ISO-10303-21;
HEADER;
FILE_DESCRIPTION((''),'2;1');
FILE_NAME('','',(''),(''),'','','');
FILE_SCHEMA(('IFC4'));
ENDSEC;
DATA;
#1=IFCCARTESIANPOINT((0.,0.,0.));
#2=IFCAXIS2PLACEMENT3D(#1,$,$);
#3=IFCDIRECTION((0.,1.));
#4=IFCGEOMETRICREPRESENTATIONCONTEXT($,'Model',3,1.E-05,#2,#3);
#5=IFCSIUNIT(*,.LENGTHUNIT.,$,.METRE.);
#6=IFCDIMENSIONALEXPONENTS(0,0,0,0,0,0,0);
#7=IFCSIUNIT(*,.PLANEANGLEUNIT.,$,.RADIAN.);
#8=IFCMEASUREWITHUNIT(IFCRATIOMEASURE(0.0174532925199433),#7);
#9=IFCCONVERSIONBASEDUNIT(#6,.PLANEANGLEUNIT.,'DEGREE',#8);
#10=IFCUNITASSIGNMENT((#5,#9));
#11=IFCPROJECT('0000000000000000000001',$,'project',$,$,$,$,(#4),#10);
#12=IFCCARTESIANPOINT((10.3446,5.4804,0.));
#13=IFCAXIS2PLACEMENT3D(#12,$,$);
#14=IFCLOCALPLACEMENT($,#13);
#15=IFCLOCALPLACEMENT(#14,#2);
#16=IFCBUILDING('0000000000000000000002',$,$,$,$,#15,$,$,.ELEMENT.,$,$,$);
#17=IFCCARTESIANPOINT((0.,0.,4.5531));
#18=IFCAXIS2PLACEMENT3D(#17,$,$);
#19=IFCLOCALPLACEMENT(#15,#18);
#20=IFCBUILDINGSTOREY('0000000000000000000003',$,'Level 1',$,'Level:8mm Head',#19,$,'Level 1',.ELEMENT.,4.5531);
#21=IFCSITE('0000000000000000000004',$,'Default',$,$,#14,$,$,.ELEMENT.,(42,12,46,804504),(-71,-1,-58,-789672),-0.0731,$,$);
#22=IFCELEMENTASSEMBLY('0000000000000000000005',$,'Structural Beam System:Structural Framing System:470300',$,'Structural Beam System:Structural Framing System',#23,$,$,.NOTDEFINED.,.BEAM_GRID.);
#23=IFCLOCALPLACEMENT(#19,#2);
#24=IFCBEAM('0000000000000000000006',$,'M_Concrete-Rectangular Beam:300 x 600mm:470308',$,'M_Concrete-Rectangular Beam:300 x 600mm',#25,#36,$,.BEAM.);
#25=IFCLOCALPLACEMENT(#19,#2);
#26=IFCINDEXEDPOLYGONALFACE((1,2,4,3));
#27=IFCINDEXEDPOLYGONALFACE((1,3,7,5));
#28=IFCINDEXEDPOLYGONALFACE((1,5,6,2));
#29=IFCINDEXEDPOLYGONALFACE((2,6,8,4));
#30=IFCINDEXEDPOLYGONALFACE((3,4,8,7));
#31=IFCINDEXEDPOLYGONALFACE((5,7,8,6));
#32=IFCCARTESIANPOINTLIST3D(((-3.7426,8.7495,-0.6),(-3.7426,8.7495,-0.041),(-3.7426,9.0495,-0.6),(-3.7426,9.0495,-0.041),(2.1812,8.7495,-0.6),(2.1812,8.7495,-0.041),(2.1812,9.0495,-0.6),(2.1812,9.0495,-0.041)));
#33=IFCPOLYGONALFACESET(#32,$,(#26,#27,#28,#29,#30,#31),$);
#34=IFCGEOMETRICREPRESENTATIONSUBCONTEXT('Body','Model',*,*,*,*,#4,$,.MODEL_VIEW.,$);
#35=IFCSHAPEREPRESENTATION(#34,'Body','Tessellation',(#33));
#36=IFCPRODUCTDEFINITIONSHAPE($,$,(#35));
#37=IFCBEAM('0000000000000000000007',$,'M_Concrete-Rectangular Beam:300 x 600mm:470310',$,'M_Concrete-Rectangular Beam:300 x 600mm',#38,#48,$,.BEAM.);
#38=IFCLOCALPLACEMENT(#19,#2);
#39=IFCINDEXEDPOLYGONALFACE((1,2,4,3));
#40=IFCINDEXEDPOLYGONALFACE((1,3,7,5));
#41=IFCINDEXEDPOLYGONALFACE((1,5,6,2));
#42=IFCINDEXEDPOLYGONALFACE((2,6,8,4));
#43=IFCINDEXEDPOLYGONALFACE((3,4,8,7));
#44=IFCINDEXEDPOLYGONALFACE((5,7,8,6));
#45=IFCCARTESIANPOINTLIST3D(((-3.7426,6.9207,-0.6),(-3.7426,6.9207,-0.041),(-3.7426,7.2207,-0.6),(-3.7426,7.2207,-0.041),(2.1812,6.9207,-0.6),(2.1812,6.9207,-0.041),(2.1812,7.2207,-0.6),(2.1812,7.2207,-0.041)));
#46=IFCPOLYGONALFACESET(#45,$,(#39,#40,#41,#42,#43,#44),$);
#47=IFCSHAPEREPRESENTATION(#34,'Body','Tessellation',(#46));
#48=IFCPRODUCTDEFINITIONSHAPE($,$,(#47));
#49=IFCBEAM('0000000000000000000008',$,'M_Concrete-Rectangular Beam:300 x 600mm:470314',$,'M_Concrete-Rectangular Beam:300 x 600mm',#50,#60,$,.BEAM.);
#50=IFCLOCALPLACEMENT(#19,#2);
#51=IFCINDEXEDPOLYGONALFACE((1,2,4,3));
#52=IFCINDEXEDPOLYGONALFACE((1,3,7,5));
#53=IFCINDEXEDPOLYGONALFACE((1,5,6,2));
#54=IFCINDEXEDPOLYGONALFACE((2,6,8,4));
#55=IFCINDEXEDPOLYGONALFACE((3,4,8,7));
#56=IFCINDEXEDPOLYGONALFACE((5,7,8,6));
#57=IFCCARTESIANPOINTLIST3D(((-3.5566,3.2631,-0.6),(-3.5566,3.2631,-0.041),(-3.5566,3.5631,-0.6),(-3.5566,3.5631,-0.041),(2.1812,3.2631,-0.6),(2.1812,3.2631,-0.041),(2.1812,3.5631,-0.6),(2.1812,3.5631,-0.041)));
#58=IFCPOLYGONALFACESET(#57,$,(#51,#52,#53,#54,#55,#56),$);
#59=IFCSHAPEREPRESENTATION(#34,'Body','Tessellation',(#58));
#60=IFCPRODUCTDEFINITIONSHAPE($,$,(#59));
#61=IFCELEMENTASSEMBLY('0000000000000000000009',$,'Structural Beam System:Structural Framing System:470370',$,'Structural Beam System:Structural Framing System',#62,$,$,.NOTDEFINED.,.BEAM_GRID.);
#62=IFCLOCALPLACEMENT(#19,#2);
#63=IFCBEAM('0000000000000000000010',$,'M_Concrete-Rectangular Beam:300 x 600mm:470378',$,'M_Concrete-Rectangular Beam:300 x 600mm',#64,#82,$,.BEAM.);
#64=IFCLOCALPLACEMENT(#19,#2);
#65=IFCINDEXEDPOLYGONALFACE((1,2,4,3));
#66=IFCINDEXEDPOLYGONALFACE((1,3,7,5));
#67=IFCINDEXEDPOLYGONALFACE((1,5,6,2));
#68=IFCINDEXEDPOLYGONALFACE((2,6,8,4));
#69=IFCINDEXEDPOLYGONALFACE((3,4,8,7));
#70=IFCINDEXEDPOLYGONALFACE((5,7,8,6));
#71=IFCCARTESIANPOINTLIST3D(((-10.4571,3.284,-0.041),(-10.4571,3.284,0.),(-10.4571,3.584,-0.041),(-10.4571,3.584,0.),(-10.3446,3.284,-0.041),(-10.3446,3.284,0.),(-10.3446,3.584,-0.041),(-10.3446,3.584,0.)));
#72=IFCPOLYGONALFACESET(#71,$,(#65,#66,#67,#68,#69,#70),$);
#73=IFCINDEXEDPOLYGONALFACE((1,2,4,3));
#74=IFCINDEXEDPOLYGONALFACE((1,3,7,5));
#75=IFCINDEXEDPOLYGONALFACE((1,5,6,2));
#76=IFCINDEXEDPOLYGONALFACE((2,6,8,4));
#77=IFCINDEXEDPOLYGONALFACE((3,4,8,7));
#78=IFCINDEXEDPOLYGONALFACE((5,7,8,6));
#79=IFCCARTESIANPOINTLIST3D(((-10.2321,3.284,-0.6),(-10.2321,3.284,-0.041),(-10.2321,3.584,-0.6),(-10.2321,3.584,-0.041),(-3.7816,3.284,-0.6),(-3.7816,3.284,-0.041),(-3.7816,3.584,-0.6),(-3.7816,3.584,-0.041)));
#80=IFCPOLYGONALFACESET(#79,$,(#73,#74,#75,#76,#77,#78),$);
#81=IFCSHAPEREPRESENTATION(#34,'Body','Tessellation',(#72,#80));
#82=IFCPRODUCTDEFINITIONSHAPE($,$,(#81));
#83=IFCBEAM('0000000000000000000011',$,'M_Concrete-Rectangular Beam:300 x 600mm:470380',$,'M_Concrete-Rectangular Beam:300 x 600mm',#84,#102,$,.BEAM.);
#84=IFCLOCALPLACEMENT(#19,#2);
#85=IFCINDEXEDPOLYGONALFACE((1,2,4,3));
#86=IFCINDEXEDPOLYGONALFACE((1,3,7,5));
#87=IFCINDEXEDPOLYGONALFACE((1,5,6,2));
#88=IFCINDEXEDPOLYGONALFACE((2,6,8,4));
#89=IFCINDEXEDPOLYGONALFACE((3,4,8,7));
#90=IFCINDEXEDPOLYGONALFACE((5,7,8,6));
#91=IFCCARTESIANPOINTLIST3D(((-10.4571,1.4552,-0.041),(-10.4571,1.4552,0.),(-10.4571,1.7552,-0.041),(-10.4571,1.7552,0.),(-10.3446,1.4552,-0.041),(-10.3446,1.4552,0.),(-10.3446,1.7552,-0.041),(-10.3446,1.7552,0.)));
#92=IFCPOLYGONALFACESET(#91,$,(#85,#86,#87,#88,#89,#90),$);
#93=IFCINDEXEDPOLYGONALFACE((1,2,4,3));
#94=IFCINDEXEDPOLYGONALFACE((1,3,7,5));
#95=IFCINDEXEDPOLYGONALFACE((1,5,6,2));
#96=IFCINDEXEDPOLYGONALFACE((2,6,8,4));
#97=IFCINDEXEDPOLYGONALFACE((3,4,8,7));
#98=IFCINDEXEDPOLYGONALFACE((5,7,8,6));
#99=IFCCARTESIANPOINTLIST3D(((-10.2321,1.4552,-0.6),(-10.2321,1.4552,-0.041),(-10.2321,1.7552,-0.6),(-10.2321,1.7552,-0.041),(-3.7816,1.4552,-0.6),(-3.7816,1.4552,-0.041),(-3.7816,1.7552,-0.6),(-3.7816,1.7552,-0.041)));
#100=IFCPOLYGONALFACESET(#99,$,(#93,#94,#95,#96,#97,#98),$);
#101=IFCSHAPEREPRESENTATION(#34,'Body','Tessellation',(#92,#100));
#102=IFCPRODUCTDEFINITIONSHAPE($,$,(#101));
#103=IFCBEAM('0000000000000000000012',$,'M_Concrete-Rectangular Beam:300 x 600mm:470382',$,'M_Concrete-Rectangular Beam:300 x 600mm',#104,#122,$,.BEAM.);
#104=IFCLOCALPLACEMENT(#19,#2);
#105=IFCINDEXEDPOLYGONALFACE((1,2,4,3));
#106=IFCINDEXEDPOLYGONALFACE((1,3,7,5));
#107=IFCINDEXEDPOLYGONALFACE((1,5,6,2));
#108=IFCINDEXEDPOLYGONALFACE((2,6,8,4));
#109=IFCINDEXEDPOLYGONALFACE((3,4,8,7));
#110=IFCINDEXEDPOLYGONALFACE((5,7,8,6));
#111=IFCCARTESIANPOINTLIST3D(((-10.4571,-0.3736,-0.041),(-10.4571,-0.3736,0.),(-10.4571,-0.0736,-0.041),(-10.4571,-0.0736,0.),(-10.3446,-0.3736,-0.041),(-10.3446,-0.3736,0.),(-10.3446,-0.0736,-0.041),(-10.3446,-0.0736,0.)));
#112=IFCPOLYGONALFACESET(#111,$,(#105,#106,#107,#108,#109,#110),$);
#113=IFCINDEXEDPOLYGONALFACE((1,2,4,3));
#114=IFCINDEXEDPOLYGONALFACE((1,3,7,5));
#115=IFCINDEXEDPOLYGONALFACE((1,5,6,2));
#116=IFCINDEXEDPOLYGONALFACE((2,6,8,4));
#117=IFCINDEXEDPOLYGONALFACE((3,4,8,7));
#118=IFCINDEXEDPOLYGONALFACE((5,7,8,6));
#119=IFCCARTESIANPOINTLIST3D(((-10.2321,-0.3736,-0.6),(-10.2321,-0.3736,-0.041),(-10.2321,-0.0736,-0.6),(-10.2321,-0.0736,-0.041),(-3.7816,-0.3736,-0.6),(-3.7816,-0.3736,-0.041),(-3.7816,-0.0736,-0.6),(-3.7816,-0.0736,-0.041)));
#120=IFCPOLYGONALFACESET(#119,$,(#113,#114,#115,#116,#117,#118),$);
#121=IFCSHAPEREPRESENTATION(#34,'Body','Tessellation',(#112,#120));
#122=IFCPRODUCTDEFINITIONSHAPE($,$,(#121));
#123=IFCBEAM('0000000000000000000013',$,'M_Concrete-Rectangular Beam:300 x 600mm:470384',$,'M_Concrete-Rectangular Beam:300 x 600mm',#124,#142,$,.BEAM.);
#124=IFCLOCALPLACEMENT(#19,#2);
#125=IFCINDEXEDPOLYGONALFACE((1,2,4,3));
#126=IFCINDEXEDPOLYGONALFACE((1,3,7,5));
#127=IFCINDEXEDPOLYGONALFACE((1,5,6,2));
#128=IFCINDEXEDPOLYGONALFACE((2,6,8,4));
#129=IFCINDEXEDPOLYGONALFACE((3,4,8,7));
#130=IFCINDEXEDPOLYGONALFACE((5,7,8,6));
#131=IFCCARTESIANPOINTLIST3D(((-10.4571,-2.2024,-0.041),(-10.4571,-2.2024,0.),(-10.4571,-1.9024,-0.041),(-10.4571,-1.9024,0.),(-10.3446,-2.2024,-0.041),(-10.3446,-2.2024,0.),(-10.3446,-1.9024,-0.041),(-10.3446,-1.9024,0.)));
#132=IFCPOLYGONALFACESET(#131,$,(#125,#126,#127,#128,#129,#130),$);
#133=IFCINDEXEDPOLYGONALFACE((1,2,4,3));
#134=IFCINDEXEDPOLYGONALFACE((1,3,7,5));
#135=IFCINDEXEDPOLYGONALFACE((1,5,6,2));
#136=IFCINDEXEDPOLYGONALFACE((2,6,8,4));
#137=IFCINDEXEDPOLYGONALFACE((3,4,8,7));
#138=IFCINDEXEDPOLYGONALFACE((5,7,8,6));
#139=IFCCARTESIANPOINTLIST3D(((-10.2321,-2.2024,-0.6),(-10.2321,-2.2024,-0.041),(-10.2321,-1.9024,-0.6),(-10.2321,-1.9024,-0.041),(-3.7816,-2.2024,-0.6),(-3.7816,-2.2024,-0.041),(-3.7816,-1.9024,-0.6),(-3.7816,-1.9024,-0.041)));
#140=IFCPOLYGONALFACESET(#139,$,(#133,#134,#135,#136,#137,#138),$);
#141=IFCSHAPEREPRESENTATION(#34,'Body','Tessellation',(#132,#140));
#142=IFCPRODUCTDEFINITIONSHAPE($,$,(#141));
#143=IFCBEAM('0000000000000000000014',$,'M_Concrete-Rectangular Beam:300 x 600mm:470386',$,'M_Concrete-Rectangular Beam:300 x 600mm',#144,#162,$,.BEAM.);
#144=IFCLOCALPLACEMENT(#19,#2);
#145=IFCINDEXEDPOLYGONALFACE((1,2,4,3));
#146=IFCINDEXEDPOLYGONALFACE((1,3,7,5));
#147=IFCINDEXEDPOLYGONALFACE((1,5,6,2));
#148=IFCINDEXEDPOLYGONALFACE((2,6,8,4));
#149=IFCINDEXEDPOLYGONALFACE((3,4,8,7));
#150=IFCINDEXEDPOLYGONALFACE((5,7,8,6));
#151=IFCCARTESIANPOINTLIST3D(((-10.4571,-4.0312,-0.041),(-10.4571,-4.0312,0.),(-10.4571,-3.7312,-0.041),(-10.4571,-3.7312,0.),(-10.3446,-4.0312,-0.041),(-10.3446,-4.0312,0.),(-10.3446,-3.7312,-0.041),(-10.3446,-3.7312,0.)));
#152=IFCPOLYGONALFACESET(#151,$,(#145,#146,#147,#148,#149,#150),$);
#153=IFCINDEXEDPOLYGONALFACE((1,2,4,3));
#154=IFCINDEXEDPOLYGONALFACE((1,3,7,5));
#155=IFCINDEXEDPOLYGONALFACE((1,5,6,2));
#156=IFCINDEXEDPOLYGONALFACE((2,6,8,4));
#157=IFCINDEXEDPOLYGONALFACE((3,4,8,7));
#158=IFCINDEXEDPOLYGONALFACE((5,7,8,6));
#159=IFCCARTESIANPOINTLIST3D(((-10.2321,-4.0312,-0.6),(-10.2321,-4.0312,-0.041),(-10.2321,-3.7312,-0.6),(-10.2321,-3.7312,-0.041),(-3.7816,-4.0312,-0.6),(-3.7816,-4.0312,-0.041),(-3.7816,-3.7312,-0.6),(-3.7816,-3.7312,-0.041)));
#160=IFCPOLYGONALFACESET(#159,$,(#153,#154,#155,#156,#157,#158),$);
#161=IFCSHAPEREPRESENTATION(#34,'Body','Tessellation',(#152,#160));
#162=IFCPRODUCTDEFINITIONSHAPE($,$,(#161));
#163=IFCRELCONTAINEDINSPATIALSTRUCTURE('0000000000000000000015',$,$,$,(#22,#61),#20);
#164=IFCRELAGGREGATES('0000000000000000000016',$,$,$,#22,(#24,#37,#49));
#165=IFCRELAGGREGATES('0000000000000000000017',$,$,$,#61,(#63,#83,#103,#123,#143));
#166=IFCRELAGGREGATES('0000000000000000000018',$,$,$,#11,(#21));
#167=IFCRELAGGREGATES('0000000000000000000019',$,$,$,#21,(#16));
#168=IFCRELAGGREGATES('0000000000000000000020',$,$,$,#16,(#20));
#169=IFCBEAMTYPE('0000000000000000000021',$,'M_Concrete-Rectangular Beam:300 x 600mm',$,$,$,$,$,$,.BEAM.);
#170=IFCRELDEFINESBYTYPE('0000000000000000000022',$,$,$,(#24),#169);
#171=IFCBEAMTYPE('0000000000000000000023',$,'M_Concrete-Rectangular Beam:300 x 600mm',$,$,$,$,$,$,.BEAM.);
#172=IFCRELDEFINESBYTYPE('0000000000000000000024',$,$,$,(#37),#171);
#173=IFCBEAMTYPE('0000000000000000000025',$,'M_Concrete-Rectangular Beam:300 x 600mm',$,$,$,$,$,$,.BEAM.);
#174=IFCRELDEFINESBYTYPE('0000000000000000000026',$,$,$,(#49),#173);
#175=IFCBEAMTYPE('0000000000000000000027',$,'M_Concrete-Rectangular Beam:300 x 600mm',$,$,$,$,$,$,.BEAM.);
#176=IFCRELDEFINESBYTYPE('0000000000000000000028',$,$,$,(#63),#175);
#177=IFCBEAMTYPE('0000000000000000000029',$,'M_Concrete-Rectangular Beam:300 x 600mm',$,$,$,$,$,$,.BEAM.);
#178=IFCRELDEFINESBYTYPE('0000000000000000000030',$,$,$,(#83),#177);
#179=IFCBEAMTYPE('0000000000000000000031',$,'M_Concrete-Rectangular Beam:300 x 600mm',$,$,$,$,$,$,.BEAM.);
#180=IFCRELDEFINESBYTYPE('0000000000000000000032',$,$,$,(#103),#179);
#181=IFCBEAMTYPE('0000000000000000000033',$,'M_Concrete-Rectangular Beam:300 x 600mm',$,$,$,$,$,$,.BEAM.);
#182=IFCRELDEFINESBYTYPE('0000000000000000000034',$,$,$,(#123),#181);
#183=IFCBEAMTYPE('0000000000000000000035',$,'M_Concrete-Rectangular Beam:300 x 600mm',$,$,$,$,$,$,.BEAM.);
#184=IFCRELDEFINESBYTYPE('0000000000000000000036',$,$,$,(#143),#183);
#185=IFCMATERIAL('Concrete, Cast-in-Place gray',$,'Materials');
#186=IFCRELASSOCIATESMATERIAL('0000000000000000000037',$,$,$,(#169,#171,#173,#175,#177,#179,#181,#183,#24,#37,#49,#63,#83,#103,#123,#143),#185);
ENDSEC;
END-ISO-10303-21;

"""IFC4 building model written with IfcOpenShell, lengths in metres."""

from ifc_helpers import new_model, entity, si_unit, converted_unit, direction, frame, frame_2d, origin, place, context, subcontext, project, spatial, rectangle, extrude, source, transform, mapped, material, material_profile, profile_set, profile_usage, type_object, type_shapes, element, aggregate, save


model = new_model("IFC4")

# Units and contexts
model_context = context("Model", 3, precision=1e-05, world=origin(), true_north=direction((0.0, 1.0)))
body_context = subcontext(model_context, "Body", "Model", "MODEL_VIEW")
ifc_project = project(units=[si_unit("LENGTHUNIT", "METRE"), converted_unit("PLANEANGLEUNIT", "DEGREE", entity("IfcRatioMeasure", 0.0174532925199433), si_unit("PLANEANGLEUNIT", "RADIAN"), dimensions=[0, 0, 0, 0, 0, 0, 0])], contexts=[model_context])

# Site, building, storey
site_placement = place(None, frame((10.3446, 5.4804, 0.0)))
site = spatial("IfcSite", under=ifc_project, at=site_placement, Name="Default", CompositionType="ELEMENT", RefLatitude=(42, 12, 46, 804504), RefLongitude=(-71, -1, -58, -789672), RefElevation=-0.0731)
building_placement = place(site_placement, origin())
building = spatial("IfcBuilding", under=site, at=building_placement, CompositionType="ELEMENT")
storey_placement = place(building_placement, frame((0.0, 0.0, 4.5531)))
storey = spatial("IfcBuildingStorey", under=building, at=storey_placement, Name="Level 1", ObjectType="Level:8mm Head", LongName="Level 1", CompositionType="ELEMENT", Elevation=4.5531)

# Element assemblies, beams
assembly_1_placement = place(storey_placement, origin())
assembly_1 = element("IfcElementAssembly", 1, at=assembly_1_placement, inside=storey, Name="Structural Beam System:Structural Framing System:470300", ObjectType="Structural Beam System:Structural Framing System", AssemblyPlace="NOTDEFINED", PredefinedType="BEAM_GRID")
ifc_material_1 = material(Name="Concrete, Cast-in-Place gray", Category="Materials")
ifc_material_profile = material_profile(ifc_material_1, rectangle(XDim=0.559, YDim=0.3, at=frame_2d((0.0, 0.0), x_axis=(1.0, 0.0))), Name="300 x 600mm")
ifc_profile_set = profile_set([ifc_material_profile], Name="300 x 600mm")
ifc_profile_usage_1 = profile_usage(ifc_profile_set, cardinal=8)
beam_type_1 = type_object("IfcBeamType", Name="M_Concrete-Rectangular Beam:300 x 600mm", PredefinedType="BEAM", material=ifc_profile_set)
shared_shape_1 = source(origin(), body_context, "Body", "SweptSolid", [
    extrude(rectangle(XDim=0.559, YDim=0.3, at=frame_2d((0.0, 0.0), x_axis=(1.0, 0.0))), frame((-3.7426, 8.8995, 4.2326), z_axis=(1.0, 0.0, 0.0), x_axis=(0.0, 0.0, -1.0)), (0.0, 0.0, 1.0), 5.9238),
])
type_shapes(beam_type_1, [shared_shape_1])
beam_1_placement = place(assembly_1_placement, frame((0.0, 0.0, -4.5531)))
beam_1 = element("IfcBeam", 2, at=beam_1_placement, type_object=beam_type_1, material=ifc_profile_usage_1, Name="M_Concrete-Rectangular Beam:300 x 600mm:470308", ObjectType="M_Concrete-Rectangular Beam:300 x 600mm", PredefinedType="BEAM", context=body_context, shape_type="MappedRepresentation", body=[
    mapped(shared_shape_1, transform((0.0, 0.0, 0.0), scale=1.0)),
])
ifc_profile_usage_2 = profile_usage(ifc_profile_set, cardinal=8)
beam_type_2 = type_object("IfcBeamType", Name="M_Concrete-Rectangular Beam:300 x 600mm", PredefinedType="BEAM", material=ifc_profile_set)
shared_shape_2 = source(origin(), body_context, "Body", "SweptSolid", [
    extrude(rectangle(XDim=0.559, YDim=0.3, at=frame_2d((0.0, 0.0), x_axis=(1.0, 0.0))), frame((-3.7426, 7.0707, 4.2326), z_axis=(1.0, 0.0, 0.0), x_axis=(0.0, 0.0, -1.0)), (0.0, 0.0, 1.0), 5.9238),
])
type_shapes(beam_type_2, [shared_shape_2])
beam_2_placement = place(assembly_1_placement, frame((0.0, 0.0, -4.5531)))
beam_2 = element("IfcBeam", 3, at=beam_2_placement, type_object=beam_type_2, material=ifc_profile_usage_2, Name="M_Concrete-Rectangular Beam:300 x 600mm:470310", ObjectType="M_Concrete-Rectangular Beam:300 x 600mm", PredefinedType="BEAM", context=body_context, shape_type="MappedRepresentation", body=[
    mapped(shared_shape_2, transform((0.0, 0.0, 0.0), scale=1.0)),
])
ifc_profile_usage_3 = profile_usage(ifc_profile_set, cardinal=8)
beam_type_3 = type_object("IfcBeamType", Name="M_Concrete-Rectangular Beam:300 x 600mm", PredefinedType="BEAM", material=ifc_profile_set)
shared_shape_3 = source(origin(), body_context, "Body", "SweptSolid", [
    extrude(rectangle(XDim=0.559, YDim=0.3, at=frame_2d((0.0, 0.0), x_axis=(1.0, 0.0))), frame((-3.5566, 3.4131, 4.2326), z_axis=(1.0, 0.0, 0.0), x_axis=(0.0, 0.0, -1.0)), (0.0, 0.0, 1.0), 5.7377),
])
type_shapes(beam_type_3, [shared_shape_3])
beam_3_placement = place(assembly_1_placement, frame((0.0, 0.0, -4.5531)))
beam_3 = element("IfcBeam", 4, at=beam_3_placement, type_object=beam_type_3, material=ifc_profile_usage_3, Name="M_Concrete-Rectangular Beam:300 x 600mm:470314", ObjectType="M_Concrete-Rectangular Beam:300 x 600mm", PredefinedType="BEAM", context=body_context, shape_type="MappedRepresentation", body=[
    mapped(shared_shape_3, transform((0.0, 0.0, 0.0), scale=1.0)),
])
aggregate(assembly_1, [beam_1, beam_2, beam_3])
assembly_2_placement = place(storey_placement, origin())
assembly_2 = element("IfcElementAssembly", 5, at=assembly_2_placement, inside=storey, Name="Structural Beam System:Structural Framing System:470370", ObjectType="Structural Beam System:Structural Framing System", AssemblyPlace="NOTDEFINED", PredefinedType="BEAM_GRID")
ifc_profile_usage_4 = profile_usage(ifc_profile_set, cardinal=8)
beam_type_4 = type_object("IfcBeamType", Name="M_Concrete-Rectangular Beam:300 x 600mm", PredefinedType="BEAM", material=ifc_profile_set)
shared_shape_4 = source(origin(), body_context, "Body", "SweptSolid", [
    extrude(rectangle(XDim=0.041, YDim=0.3, at=frame_2d((0.0, 0.0), x_axis=(1.0, 0.0))), frame((-10.4571, 3.434, 4.5326), z_axis=(1.0, 0.0, 0.0), x_axis=(0.0, 0.0, -1.0)), (0.0, 0.0, 1.0), 0.1125),
    extrude(rectangle(XDim=0.559, YDim=0.3, at=frame_2d((0.0, 0.0), x_axis=(1.0, 0.0))), frame((-10.2321, 3.434, 4.2326), z_axis=(1.0, 0.0, 0.0), x_axis=(0.0, 0.0, -1.0)), (0.0, 0.0, 1.0), 6.4506),
])
type_shapes(beam_type_4, [shared_shape_4])
beam_4_placement = place(assembly_2_placement, frame((0.0, 0.0, -4.5531)))
beam_4 = element("IfcBeam", 6, at=beam_4_placement, type_object=beam_type_4, material=ifc_profile_usage_4, Name="M_Concrete-Rectangular Beam:300 x 600mm:470378", ObjectType="M_Concrete-Rectangular Beam:300 x 600mm", PredefinedType="BEAM", context=body_context, shape_type="MappedRepresentation", body=[
    mapped(shared_shape_4, transform((0.0, 0.0, 0.0), scale=1.0)),
])
ifc_profile_usage_5 = profile_usage(ifc_profile_set, cardinal=8)
beam_type_5 = type_object("IfcBeamType", Name="M_Concrete-Rectangular Beam:300 x 600mm", PredefinedType="BEAM", material=ifc_profile_set)
shared_shape_5 = source(origin(), body_context, "Body", "SweptSolid", [
    extrude(rectangle(XDim=0.041, YDim=0.3, at=frame_2d((0.0, 0.0), x_axis=(1.0, 0.0))), frame((-10.4571, 1.6052, 4.5326), z_axis=(1.0, 0.0, 0.0), x_axis=(0.0, 0.0, -1.0)), (0.0, 0.0, 1.0), 0.1125),
    extrude(rectangle(XDim=0.559, YDim=0.3, at=frame_2d((0.0, 0.0), x_axis=(1.0, 0.0))), frame((-10.2321, 1.6052, 4.2326), z_axis=(1.0, 0.0, 0.0), x_axis=(0.0, 0.0, -1.0)), (0.0, 0.0, 1.0), 6.4506),
])
type_shapes(beam_type_5, [shared_shape_5])
beam_5_placement = place(assembly_2_placement, frame((0.0, 0.0, -4.5531)))
beam_5 = element("IfcBeam", 7, at=beam_5_placement, type_object=beam_type_5, material=ifc_profile_usage_5, Name="M_Concrete-Rectangular Beam:300 x 600mm:470380", ObjectType="M_Concrete-Rectangular Beam:300 x 600mm", PredefinedType="BEAM", context=body_context, shape_type="MappedRepresentation", body=[
    mapped(shared_shape_5, transform((0.0, 0.0, 0.0), scale=1.0)),
])
ifc_profile_usage_6 = profile_usage(ifc_profile_set, cardinal=8)
beam_type_6 = type_object("IfcBeamType", Name="M_Concrete-Rectangular Beam:300 x 600mm", PredefinedType="BEAM", material=ifc_profile_set)
shared_shape_6 = source(origin(), body_context, "Body", "SweptSolid", [
    extrude(rectangle(XDim=0.041, YDim=0.3, at=frame_2d((0.0, 0.0), x_axis=(1.0, 0.0))), frame((-10.4571, -0.2236, 4.5326), z_axis=(1.0, 0.0, 0.0), x_axis=(0.0, 0.0, -1.0)), (0.0, 0.0, 1.0), 0.1125),
    extrude(rectangle(XDim=0.559, YDim=0.3, at=frame_2d((0.0, 0.0), x_axis=(1.0, 0.0))), frame((-10.2321, -0.2236, 4.2326), z_axis=(1.0, 0.0, 0.0), x_axis=(0.0, 0.0, -1.0)), (0.0, 0.0, 1.0), 6.4506),
])
type_shapes(beam_type_6, [shared_shape_6])
beam_6_placement = place(assembly_2_placement, frame((0.0, 0.0, -4.5531)))
beam_6 = element("IfcBeam", 8, at=beam_6_placement, type_object=beam_type_6, material=ifc_profile_usage_6, Name="M_Concrete-Rectangular Beam:300 x 600mm:470382", ObjectType="M_Concrete-Rectangular Beam:300 x 600mm", PredefinedType="BEAM", context=body_context, shape_type="MappedRepresentation", body=[
    mapped(shared_shape_6, transform((0.0, 0.0, 0.0), scale=1.0)),
])
ifc_profile_usage_7 = profile_usage(ifc_profile_set, cardinal=8)
beam_type_7 = type_object("IfcBeamType", Name="M_Concrete-Rectangular Beam:300 x 600mm", PredefinedType="BEAM", material=ifc_profile_set)
shared_shape_7 = source(origin(), body_context, "Body", "SweptSolid", [
    extrude(rectangle(XDim=0.041, YDim=0.3, at=frame_2d((0.0, 0.0), x_axis=(1.0, 0.0))), frame((-10.4571, -2.0524, 4.5326), z_axis=(1.0, 0.0, 0.0), x_axis=(0.0, 0.0, -1.0)), (0.0, 0.0, 1.0), 0.1125),
    extrude(rectangle(XDim=0.559, YDim=0.3, at=frame_2d((0.0, 0.0), x_axis=(1.0, 0.0))), frame((-10.2321, -2.0524, 4.2326), z_axis=(1.0, 0.0, 0.0), x_axis=(0.0, 0.0, -1.0)), (0.0, 0.0, 1.0), 6.4506),
])
type_shapes(beam_type_7, [shared_shape_7])
beam_7_placement = place(assembly_2_placement, frame((0.0, 0.0, -4.5531)))
beam_7 = element("IfcBeam", 9, at=beam_7_placement, type_object=beam_type_7, material=ifc_profile_usage_7, Name="M_Concrete-Rectangular Beam:300 x 600mm:470384", ObjectType="M_Concrete-Rectangular Beam:300 x 600mm", PredefinedType="BEAM", context=body_context, shape_type="MappedRepresentation", body=[
    mapped(shared_shape_7, transform((0.0, 0.0, 0.0), scale=1.0)),
])
ifc_profile_usage_8 = profile_usage(ifc_profile_set, cardinal=8)
beam_type_8 = type_object("IfcBeamType", Name="M_Concrete-Rectangular Beam:300 x 600mm", PredefinedType="BEAM", material=ifc_profile_set)
shared_shape_8 = source(origin(), body_context, "Body", "SweptSolid", [
    extrude(rectangle(XDim=0.041, YDim=0.3, at=frame_2d((0.0, 0.0), x_axis=(1.0, 0.0))), frame((-10.4571, -3.8812, 4.5326), z_axis=(1.0, 0.0, 0.0), x_axis=(0.0, 0.0, -1.0)), (0.0, 0.0, 1.0), 0.1125),
    extrude(rectangle(XDim=0.559, YDim=0.3, at=frame_2d((0.0, 0.0), x_axis=(1.0, 0.0))), frame((-10.2321, -3.8812, 4.2326), z_axis=(1.0, 0.0, 0.0), x_axis=(0.0, 0.0, -1.0)), (0.0, 0.0, 1.0), 6.4506),
])
type_shapes(beam_type_8, [shared_shape_8])
beam_8_placement = place(assembly_2_placement, frame((0.0, 0.0, -4.5531)))
beam_8 = element("IfcBeam", 10, at=beam_8_placement, type_object=beam_type_8, material=ifc_profile_usage_8, Name="M_Concrete-Rectangular Beam:300 x 600mm:470386", ObjectType="M_Concrete-Rectangular Beam:300 x 600mm", PredefinedType="BEAM", context=body_context, shape_type="MappedRepresentation", body=[
    mapped(shared_shape_8, transform((0.0, 0.0, 0.0), scale=1.0)),
])
aggregate(assembly_2, [beam_4, beam_5, beam_6, beam_7, beam_8])

save(model, "model.ifc")
